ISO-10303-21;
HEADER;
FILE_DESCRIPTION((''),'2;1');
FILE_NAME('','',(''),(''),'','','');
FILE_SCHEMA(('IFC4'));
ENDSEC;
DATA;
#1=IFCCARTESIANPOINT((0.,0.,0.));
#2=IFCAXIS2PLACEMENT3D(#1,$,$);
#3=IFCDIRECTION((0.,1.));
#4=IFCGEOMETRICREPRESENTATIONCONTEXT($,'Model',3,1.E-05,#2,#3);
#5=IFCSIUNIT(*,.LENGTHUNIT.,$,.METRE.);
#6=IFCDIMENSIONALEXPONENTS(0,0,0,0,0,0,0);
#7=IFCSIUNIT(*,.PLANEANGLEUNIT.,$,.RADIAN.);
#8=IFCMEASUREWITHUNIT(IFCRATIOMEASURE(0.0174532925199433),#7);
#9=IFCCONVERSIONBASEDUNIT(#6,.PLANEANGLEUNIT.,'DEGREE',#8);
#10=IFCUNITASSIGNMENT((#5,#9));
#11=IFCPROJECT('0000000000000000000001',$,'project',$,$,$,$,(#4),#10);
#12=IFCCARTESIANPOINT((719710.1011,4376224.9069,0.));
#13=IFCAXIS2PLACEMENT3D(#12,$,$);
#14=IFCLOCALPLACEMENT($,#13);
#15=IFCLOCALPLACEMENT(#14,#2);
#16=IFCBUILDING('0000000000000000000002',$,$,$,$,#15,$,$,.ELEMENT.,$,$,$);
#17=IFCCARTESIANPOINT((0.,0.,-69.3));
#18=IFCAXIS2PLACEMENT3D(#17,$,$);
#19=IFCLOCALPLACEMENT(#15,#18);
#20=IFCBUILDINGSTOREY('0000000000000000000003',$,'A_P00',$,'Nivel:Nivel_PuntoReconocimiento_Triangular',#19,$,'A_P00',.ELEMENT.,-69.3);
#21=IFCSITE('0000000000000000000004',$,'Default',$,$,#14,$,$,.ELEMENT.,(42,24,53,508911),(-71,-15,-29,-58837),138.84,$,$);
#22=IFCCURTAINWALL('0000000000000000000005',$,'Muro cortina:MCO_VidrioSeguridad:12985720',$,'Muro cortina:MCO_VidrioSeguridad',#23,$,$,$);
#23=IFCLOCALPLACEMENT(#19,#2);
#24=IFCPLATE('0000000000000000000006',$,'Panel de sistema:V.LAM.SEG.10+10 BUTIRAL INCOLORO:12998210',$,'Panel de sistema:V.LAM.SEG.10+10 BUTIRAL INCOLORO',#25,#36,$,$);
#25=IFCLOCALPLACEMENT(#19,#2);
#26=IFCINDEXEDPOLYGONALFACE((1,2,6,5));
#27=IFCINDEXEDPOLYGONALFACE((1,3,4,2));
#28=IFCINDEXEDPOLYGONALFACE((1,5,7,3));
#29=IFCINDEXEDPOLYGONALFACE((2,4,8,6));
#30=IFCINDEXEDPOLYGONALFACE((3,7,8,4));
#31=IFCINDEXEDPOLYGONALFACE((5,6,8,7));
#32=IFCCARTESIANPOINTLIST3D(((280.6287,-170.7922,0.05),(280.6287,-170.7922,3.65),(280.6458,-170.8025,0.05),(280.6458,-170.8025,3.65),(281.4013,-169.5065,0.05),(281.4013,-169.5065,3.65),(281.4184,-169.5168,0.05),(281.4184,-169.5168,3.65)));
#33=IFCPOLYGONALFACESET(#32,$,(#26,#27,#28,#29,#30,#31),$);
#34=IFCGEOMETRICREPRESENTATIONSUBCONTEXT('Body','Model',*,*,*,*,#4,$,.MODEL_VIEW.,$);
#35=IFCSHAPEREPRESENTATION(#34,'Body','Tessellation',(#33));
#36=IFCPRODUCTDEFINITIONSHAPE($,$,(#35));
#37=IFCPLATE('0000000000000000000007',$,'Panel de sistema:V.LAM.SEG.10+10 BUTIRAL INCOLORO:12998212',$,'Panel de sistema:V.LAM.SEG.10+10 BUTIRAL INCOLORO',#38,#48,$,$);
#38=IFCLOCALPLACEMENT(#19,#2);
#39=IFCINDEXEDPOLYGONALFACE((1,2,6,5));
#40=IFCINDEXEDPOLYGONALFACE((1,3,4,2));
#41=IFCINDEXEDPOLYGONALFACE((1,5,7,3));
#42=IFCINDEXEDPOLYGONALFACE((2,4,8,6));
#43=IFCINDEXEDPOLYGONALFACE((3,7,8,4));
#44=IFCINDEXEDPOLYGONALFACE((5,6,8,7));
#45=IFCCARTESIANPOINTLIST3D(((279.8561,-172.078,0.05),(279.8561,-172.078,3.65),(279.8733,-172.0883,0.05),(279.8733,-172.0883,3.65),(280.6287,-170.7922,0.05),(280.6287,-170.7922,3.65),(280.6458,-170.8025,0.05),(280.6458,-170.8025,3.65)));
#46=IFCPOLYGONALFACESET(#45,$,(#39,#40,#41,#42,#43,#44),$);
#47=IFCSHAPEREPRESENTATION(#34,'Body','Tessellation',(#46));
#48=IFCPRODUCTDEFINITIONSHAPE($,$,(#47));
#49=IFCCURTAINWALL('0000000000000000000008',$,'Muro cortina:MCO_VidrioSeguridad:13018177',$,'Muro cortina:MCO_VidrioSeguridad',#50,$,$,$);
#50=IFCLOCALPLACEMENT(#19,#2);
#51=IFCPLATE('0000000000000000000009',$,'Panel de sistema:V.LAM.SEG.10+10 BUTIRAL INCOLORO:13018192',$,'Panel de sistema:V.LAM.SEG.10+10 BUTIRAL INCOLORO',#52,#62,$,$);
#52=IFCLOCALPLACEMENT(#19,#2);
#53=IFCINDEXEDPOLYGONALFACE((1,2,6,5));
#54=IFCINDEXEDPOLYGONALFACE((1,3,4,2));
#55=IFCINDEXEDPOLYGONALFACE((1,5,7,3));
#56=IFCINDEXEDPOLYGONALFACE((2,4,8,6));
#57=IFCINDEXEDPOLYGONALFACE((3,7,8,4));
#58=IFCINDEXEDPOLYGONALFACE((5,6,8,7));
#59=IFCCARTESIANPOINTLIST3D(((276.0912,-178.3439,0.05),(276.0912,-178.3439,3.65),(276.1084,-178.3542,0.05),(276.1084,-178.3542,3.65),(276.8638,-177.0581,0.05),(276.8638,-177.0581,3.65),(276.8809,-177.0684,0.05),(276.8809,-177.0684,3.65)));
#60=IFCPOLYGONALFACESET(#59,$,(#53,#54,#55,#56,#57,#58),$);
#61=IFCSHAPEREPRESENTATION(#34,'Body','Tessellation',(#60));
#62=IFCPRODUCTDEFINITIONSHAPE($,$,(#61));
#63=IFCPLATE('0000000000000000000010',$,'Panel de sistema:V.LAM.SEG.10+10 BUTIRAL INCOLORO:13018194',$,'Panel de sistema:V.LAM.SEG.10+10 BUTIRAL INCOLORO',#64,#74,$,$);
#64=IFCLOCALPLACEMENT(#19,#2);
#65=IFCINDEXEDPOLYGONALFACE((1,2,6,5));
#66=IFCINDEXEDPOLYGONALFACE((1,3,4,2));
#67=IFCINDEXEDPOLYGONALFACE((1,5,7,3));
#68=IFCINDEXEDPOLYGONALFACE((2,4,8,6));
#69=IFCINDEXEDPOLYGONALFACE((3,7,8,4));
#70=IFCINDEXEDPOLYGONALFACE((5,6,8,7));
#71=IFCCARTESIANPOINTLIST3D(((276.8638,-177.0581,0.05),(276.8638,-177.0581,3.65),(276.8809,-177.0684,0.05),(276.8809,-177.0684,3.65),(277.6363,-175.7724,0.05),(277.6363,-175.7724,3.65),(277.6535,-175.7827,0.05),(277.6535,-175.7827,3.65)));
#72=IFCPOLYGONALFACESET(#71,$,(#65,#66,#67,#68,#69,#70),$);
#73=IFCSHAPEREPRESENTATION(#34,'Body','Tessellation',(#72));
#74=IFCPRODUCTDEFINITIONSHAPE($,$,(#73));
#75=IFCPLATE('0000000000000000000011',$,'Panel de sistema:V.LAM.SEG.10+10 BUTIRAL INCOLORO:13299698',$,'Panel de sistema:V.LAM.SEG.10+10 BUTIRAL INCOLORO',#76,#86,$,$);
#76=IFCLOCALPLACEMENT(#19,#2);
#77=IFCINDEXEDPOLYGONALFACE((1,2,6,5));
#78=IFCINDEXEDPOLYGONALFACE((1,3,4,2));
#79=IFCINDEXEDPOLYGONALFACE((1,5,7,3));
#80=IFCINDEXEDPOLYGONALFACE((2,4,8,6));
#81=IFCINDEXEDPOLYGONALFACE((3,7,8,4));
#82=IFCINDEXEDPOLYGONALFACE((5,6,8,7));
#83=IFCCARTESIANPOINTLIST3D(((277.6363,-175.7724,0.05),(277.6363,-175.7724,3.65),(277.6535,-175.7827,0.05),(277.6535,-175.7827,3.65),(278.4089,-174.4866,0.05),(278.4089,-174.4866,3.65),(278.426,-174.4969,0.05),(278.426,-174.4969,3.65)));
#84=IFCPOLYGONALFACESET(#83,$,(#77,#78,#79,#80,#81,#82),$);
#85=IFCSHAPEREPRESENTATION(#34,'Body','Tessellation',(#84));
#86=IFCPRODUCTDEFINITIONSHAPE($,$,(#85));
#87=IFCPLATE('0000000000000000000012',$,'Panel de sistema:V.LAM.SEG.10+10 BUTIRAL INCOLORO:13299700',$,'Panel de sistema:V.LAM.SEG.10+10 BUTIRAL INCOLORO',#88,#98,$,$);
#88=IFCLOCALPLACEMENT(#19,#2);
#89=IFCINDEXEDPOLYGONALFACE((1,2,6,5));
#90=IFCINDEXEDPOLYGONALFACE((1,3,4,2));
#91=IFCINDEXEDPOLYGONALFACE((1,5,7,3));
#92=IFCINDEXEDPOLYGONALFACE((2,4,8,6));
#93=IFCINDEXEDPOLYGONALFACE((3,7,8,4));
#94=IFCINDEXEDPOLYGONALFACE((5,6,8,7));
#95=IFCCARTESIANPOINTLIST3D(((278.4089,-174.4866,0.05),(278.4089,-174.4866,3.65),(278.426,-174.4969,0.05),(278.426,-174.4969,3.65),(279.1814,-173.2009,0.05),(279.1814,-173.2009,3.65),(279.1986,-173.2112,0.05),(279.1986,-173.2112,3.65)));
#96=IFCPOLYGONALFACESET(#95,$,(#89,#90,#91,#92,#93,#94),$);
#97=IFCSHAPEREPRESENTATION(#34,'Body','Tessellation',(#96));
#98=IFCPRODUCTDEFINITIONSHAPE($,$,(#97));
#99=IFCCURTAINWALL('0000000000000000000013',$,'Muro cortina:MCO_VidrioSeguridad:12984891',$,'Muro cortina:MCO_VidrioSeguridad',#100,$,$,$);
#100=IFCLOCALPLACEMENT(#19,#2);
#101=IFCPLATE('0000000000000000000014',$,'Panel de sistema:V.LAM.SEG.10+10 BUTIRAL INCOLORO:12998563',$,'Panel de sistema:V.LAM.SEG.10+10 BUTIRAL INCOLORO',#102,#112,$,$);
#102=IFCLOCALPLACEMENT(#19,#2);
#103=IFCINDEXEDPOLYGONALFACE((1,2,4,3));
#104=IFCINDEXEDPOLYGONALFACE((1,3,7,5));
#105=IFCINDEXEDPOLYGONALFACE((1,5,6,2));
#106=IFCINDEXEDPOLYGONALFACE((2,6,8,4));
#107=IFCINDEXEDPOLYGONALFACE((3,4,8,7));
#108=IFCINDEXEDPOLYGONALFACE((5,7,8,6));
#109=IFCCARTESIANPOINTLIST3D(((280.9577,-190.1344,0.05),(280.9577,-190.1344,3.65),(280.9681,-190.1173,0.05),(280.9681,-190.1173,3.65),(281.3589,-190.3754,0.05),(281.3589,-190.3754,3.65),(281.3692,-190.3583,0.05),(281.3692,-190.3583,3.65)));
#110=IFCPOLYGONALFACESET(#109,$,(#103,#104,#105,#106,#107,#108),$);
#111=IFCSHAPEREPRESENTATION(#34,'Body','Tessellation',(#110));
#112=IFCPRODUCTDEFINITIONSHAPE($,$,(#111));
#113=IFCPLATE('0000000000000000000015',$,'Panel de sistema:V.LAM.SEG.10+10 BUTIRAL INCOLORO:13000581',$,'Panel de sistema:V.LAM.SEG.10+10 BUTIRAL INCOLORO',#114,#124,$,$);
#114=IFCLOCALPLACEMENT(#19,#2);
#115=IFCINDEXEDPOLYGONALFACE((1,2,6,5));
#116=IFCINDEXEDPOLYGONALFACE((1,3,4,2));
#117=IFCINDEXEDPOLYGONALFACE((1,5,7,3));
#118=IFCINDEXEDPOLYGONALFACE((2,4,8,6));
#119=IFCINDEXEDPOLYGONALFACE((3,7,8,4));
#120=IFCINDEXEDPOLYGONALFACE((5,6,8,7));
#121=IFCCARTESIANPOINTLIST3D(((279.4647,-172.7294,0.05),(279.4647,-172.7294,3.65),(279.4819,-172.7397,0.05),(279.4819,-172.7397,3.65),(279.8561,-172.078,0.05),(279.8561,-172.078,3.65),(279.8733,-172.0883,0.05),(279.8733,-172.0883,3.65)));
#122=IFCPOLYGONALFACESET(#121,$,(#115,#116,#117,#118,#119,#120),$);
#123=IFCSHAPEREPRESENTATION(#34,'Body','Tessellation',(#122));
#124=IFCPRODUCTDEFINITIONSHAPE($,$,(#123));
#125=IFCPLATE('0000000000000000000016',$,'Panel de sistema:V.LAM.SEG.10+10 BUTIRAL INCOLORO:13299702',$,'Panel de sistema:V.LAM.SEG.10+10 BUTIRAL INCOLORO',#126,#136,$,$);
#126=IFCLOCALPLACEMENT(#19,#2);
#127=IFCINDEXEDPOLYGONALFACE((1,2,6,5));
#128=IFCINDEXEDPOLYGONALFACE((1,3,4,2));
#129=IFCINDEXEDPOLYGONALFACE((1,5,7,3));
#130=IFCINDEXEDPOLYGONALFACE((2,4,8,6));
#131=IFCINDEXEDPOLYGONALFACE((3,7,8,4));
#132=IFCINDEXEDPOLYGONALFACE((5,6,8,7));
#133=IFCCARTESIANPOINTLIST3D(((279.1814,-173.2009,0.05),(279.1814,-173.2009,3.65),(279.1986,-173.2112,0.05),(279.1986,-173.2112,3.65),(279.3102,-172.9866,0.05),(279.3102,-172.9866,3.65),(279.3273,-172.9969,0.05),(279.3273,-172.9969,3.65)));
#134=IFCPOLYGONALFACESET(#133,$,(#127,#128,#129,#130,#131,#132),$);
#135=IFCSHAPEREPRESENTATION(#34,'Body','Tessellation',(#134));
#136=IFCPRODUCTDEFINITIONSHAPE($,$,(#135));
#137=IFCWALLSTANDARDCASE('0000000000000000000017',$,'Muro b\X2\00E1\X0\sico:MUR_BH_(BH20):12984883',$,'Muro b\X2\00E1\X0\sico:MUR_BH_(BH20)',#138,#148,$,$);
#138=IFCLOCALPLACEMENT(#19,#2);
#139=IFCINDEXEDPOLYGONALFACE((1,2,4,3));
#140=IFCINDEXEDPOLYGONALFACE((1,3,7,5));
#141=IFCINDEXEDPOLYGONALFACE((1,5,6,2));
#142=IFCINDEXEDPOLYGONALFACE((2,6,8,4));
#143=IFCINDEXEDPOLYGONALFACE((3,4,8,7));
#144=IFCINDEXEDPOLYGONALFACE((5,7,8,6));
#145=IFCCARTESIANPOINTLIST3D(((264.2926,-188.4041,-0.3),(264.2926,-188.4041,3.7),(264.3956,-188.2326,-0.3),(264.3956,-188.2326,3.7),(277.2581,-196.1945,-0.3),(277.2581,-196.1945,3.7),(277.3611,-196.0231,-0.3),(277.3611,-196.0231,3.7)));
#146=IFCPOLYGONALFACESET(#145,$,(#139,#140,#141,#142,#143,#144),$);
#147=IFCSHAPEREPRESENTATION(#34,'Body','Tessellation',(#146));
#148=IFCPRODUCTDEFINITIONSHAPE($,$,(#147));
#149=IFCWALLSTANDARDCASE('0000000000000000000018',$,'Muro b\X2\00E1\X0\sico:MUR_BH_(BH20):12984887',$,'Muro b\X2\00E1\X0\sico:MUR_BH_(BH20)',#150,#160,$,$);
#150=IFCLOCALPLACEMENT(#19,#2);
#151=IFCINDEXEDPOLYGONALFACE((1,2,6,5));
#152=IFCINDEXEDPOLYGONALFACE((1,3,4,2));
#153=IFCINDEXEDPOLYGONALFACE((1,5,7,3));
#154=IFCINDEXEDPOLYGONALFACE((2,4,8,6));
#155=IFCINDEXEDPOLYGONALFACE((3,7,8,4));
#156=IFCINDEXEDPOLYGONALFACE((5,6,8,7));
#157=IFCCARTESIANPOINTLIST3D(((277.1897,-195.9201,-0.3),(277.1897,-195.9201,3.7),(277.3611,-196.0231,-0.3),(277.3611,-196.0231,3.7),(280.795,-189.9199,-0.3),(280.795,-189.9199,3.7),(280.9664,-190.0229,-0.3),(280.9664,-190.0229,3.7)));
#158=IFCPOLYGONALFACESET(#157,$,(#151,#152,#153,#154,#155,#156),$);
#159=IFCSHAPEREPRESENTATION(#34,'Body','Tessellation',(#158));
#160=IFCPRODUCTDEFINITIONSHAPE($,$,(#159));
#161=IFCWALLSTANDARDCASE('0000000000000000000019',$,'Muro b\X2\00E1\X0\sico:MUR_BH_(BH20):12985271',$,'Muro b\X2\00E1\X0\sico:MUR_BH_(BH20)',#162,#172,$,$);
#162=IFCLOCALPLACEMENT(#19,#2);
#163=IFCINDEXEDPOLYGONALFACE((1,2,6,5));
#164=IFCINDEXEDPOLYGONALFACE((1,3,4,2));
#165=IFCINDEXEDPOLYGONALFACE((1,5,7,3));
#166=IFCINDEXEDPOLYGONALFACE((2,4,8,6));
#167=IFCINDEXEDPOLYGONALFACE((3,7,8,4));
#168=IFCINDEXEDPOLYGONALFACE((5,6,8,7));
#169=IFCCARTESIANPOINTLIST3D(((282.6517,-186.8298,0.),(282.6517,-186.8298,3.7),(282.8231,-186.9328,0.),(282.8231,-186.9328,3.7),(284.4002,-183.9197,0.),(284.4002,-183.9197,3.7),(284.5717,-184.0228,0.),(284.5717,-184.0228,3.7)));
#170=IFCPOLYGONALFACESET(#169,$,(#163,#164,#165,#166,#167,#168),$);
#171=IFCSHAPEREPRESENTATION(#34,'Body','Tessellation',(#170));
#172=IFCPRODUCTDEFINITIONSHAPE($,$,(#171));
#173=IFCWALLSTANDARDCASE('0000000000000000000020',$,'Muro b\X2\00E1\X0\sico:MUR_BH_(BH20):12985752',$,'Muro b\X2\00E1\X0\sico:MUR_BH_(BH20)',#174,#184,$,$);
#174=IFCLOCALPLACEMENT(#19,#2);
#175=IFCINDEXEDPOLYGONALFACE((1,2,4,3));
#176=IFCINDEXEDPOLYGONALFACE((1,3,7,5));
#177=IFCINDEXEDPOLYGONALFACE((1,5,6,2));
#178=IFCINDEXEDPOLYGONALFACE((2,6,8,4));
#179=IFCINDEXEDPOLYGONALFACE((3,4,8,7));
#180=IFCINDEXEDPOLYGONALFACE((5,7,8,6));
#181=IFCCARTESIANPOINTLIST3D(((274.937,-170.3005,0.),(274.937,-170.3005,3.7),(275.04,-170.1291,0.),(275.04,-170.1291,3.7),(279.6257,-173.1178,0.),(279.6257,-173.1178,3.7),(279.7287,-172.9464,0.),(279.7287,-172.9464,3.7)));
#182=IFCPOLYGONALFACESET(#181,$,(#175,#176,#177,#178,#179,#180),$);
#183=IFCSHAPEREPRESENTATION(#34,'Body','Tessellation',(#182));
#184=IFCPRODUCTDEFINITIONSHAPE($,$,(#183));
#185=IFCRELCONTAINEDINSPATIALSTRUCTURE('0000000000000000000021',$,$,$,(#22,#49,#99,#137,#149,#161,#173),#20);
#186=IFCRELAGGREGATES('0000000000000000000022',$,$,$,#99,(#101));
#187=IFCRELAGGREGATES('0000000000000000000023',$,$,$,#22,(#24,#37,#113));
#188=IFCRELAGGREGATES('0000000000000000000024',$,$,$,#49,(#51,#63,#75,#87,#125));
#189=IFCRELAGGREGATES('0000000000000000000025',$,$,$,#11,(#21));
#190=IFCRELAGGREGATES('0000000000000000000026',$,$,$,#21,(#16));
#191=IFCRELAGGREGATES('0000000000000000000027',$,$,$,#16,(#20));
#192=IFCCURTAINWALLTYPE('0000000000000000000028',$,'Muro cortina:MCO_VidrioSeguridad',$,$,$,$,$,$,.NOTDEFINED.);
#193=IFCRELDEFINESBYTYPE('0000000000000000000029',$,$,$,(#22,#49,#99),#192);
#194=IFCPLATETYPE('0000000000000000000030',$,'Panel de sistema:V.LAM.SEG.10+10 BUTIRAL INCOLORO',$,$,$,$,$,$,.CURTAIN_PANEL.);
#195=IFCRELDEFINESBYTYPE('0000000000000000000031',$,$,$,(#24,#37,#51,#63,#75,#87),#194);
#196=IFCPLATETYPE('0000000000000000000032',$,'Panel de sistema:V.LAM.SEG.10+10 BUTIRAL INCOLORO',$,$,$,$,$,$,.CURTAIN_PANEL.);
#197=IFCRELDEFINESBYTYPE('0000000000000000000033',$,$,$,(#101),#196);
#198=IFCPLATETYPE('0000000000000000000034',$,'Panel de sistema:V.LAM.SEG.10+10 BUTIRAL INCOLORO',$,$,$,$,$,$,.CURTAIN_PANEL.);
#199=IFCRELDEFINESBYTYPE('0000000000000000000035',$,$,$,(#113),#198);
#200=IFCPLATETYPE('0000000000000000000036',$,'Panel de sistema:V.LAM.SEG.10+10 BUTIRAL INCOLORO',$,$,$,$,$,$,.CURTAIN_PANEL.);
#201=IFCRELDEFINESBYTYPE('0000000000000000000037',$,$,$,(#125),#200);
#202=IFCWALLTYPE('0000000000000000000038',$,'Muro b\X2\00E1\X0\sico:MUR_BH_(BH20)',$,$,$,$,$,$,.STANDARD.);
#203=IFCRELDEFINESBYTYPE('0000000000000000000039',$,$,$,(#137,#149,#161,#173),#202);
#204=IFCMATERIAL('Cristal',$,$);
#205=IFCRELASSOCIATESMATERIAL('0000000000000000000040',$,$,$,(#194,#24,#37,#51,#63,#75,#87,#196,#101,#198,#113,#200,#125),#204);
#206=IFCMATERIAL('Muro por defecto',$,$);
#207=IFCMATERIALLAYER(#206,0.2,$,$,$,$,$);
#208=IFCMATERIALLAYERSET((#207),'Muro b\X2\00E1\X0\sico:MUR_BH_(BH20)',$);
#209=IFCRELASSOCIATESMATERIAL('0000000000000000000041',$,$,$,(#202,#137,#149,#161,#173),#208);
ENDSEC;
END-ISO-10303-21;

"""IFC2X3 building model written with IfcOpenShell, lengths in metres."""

from ifc_helpers import new_model, entity, si_unit, converted_unit, direction, frame, frame_2d, origin, origin_2d_with_axis, place, context, subcontext, project, spatial, rectangle, extrude, source, transform, mapped, material, layer, layer_set, layer_usage, type_object, type_shapes, element, aggregate, save


model = new_model("IFC2X3")

# Units and contexts
model_context = context("Model", 3, precision=1e-05, world=origin(), true_north=direction((0.0, 1.0)))
body_context = subcontext(model_context, "Body", "Model", "MODEL_VIEW")
ifc_project = project(units=[si_unit("LENGTHUNIT", "METRE"), converted_unit("PLANEANGLEUNIT", "DEGREE", entity("IfcRatioMeasure", 0.0174532925199433), si_unit("PLANEANGLEUNIT", "RADIAN"), dimensions=[0, 0, 0, 0, 0, 0, 0])], contexts=[model_context])

# Site, building, storey
site_placement = place(None, frame((719710.1011, 4376224.9069, 0.0)))
site = spatial("IfcSite", under=ifc_project, at=site_placement, Name="Default", CompositionType="ELEMENT", RefLatitude=(42, 24, 53, 508911), RefLongitude=(-71, -15, -29, -58837), RefElevation=138.84)
building_placement = place(site_placement, origin())
building = spatial("IfcBuilding", under=site, at=building_placement, CompositionType="ELEMENT")
storey_placement = place(building_placement, frame((0.0, 0.0, -69.3)))
storey = spatial("IfcBuildingStorey", under=building, at=storey_placement, Name="A_P00", ObjectType="Nivel:Nivel_PuntoReconocimiento_Triangular", LongName="A_P00", CompositionType="ELEMENT", Elevation=-69.3)

# Curtain walls, plates
curtain_wall_type = type_object("IfcCurtainWallType", Name="Muro cortina:MCO_VidrioSeguridad", PredefinedType="NOTDEFINED")
curtain_wall_1_placement = place(storey_placement, frame((0.0, 0.0, 69.3)))
curtain_wall_1 = element("IfcCurtainWall", 1, at=curtain_wall_1_placement, inside=storey, type_object=curtain_wall_type, Name="Muro cortina:MCO_VidrioSeguridad:12985720", ObjectType="Muro cortina:MCO_VidrioSeguridad")
ifc_material_1 = material(Name="Cristal")
plate_type_1 = type_object("IfcPlateType", Name="Panel de sistema:V.LAM.SEG.10+10 BUTIRAL INCOLORO", PredefinedType="CURTAIN_PANEL", material=ifc_material_1)
shared_shape_1 = source(origin(), body_context, "Body", "SweptSolid", [
    extrude(rectangle(XDim=0.02, YDim=1.5, at=origin_2d_with_axis()), frame((0.0, 0.0, 0.0), z_axis=(0.0, 0.0, 1.0), x_axis=(0.0, 1.0, 0.0)), (0.0, 0.0, 1.0), 3.6),
])
type_shapes(plate_type_1, [shared_shape_1])
plate_1_placement = place(curtain_wall_1_placement, frame((281.0236, -170.1545, -69.25), z_axis=(0.0, 0.0, 1.0), x_axis=(-0.515038, -0.857167, 0.0)))
plate_1 = element("IfcPlate", 2, at=plate_1_placement, type_object=plate_type_1, material=ifc_material_1, Name="Panel de sistema:V.LAM.SEG.10+10 BUTIRAL INCOLORO:12998210", ObjectType="Panel de sistema:V.LAM.SEG.10+10 BUTIRAL INCOLORO", context=body_context, shape_type="MappedRepresentation", body=[
    mapped(shared_shape_1, transform((0.0, 0.0, 0.0), scale=1.0)),
])
plate_2_placement = place(curtain_wall_1_placement, frame((280.251, -171.4403, -69.25), z_axis=(0.0, 0.0, 1.0), x_axis=(-0.515038, -0.857167, 0.0)))
plate_2 = element("IfcPlate", 3, at=plate_2_placement, type_object=plate_type_1, material=ifc_material_1, Name="Panel de sistema:V.LAM.SEG.10+10 BUTIRAL INCOLORO:12998212", ObjectType="Panel de sistema:V.LAM.SEG.10+10 BUTIRAL INCOLORO", context=body_context, shape_type="MappedRepresentation", body=[
    mapped(shared_shape_1, transform((0.0, 0.0, 0.0), scale=1.0)),
])
curtain_wall_2_placement = place(storey_placement, frame((0.0, 0.0, 69.3)))
curtain_wall_2 = element("IfcCurtainWall", 4, at=curtain_wall_2_placement, inside=storey, type_object=curtain_wall_type, Name="Muro cortina:MCO_VidrioSeguridad:13018177", ObjectType="Muro cortina:MCO_VidrioSeguridad")
plate_3_placement = place(curtain_wall_2_placement, frame((276.4861, -177.7062, -69.25), z_axis=(0.0, 0.0, 1.0), x_axis=(0.515038, 0.857167, 0.0)))
plate_3 = element("IfcPlate", 5, at=plate_3_placement, type_object=plate_type_1, material=ifc_material_1, Name="Panel de sistema:V.LAM.SEG.10+10 BUTIRAL INCOLORO:13018192", ObjectType="Panel de sistema:V.LAM.SEG.10+10 BUTIRAL INCOLORO", context=body_context, shape_type="MappedRepresentation", body=[
    mapped(shared_shape_1, transform((0.0, 0.0, 0.0), scale=1.0)),
])
plate_4_placement = place(curtain_wall_2_placement, frame((277.2586, -176.4204, -69.25), z_axis=(0.0, 0.0, 1.0), x_axis=(0.515038, 0.857167, 0.0)))
plate_4 = element("IfcPlate", 6, at=plate_4_placement, type_object=plate_type_1, material=ifc_material_1, Name="Panel de sistema:V.LAM.SEG.10+10 BUTIRAL INCOLORO:13018194", ObjectType="Panel de sistema:V.LAM.SEG.10+10 BUTIRAL INCOLORO", context=body_context, shape_type="MappedRepresentation", body=[
    mapped(shared_shape_1, transform((0.0, 0.0, 0.0), scale=1.0)),
])
plate_5_placement = place(curtain_wall_2_placement, frame((278.0312, -175.1346, -69.25), z_axis=(0.0, 0.0, 1.0), x_axis=(0.515038, 0.857167, 0.0)))
plate_5 = element("IfcPlate", 7, at=plate_5_placement, type_object=plate_type_1, material=ifc_material_1, Name="Panel de sistema:V.LAM.SEG.10+10 BUTIRAL INCOLORO:13299698", ObjectType="Panel de sistema:V.LAM.SEG.10+10 BUTIRAL INCOLORO", context=body_context, shape_type="MappedRepresentation", body=[
    mapped(shared_shape_1, transform((0.0, 0.0, 0.0), scale=1.0)),
])
plate_6_placement = place(curtain_wall_2_placement, frame((278.8037, -173.8489, -69.25), z_axis=(0.0, 0.0, 1.0), x_axis=(0.515038, 0.857167, 0.0)))
plate_6 = element("IfcPlate", 8, at=plate_6_placement, type_object=plate_type_1, material=ifc_material_1, Name="Panel de sistema:V.LAM.SEG.10+10 BUTIRAL INCOLORO:13299700", ObjectType="Panel de sistema:V.LAM.SEG.10+10 BUTIRAL INCOLORO", context=body_context, shape_type="MappedRepresentation", body=[
    mapped(shared_shape_1, transform((0.0, 0.0, 0.0), scale=1.0)),
])

# Curtain wall, plate
curtain_wall_3_placement = place(storey_placement, frame((0.0, 0.0, 69.3)))
curtain_wall_3 = element("IfcCurtainWall", 9, at=curtain_wall_3_placement, inside=storey, type_object=curtain_wall_type, Name="Muro cortina:MCO_VidrioSeguridad:12984891", ObjectType="Muro cortina:MCO_VidrioSeguridad")
plate_type_2 = type_object("IfcPlateType", Name="Panel de sistema:V.LAM.SEG.10+10 BUTIRAL INCOLORO", PredefinedType="CURTAIN_PANEL", material=ifc_material_1)
shared_shape_2 = source(origin(), body_context, "Body", "SweptSolid", [
    extrude(rectangle(XDim=0.02, YDim=0.468, at=origin_2d_with_axis()), frame((0.0, 0.0, 0.0), z_axis=(0.0, 0.0, 1.0), x_axis=(0.0, 1.0, 0.0)), (0.0, 0.0, 1.0), 3.6),
])
type_shapes(plate_type_2, [shared_shape_2])
plate_7_placement = place(curtain_wall_3_placement, frame((281.1635, -190.2463, -69.25), z_axis=(0.0, 0.0, 1.0), x_axis=(-0.857167, 0.515038, 0.0)))
plate_7 = element("IfcPlate", 10, at=plate_7_placement, type_object=plate_type_2, material=ifc_material_1, Name="Panel de sistema:V.LAM.SEG.10+10 BUTIRAL INCOLORO:12998563", ObjectType="Panel de sistema:V.LAM.SEG.10+10 BUTIRAL INCOLORO", context=body_context, shape_type="MappedRepresentation", body=[
    mapped(shared_shape_2, transform((0.0, 0.0, 0.0), scale=1.0)),
])
aggregate(curtain_wall_3, [plate_7])

# Plates
plate_type_3 = type_object("IfcPlateType", Name="Panel de sistema:V.LAM.SEG.10+10 BUTIRAL INCOLORO", PredefinedType="CURTAIN_PANEL", material=ifc_material_1)
shared_shape_3 = source(origin(), body_context, "Body", "SweptSolid", [
    extrude(rectangle(XDim=0.02, YDim=0.76, at=origin_2d_with_axis()), frame((0.0, 0.0, 0.0), z_axis=(0.0, 0.0, 1.0), x_axis=(0.0, 1.0, 0.0)), (0.0, 0.0, 1.0), 3.6),
])
type_shapes(plate_type_3, [shared_shape_3])
plate_8_placement = place(curtain_wall_1_placement, frame((279.669, -172.4089, -69.25), z_axis=(0.0, 0.0, 1.0), x_axis=(-0.515038, -0.857167, 0.0)))
plate_8 = element("IfcPlate", 11, at=plate_8_placement, type_object=plate_type_3, material=ifc_material_1, Name="Panel de sistema:V.LAM.SEG.10+10 BUTIRAL INCOLORO:13000581", ObjectType="Panel de sistema:V.LAM.SEG.10+10 BUTIRAL INCOLORO", context=body_context, shape_type="MappedRepresentation", body=[
    mapped(shared_shape_3, transform((0.0, 0.0, 0.0), scale=1.0)),
])
aggregate(curtain_wall_1, [plate_1, plate_2, plate_8])
plate_type_4 = type_object("IfcPlateType", Name="Panel de sistema:V.LAM.SEG.10+10 BUTIRAL INCOLORO", PredefinedType="CURTAIN_PANEL", material=ifc_material_1)
shared_shape_4 = source(origin(), body_context, "Body", "SweptSolid", [
    extrude(rectangle(XDim=0.02, YDim=0.25, at=origin_2d_with_axis()), frame((0.0, 0.0, 0.0), z_axis=(0.0, 0.0, 1.0), x_axis=(0.0, 1.0, 0.0)), (0.0, 0.0, 1.0), 3.6),
])
type_shapes(plate_type_4, [shared_shape_4])
plate_9_placement = place(curtain_wall_2_placement, frame((279.2544, -173.0989, -69.25), z_axis=(0.0, 0.0, 1.0), x_axis=(0.515038, 0.857167, 0.0)))
plate_9 = element("IfcPlate", 12, at=plate_9_placement, type_object=plate_type_4, material=ifc_material_1, Name="Panel de sistema:V.LAM.SEG.10+10 BUTIRAL INCOLORO:13299702", ObjectType="Panel de sistema:V.LAM.SEG.10+10 BUTIRAL INCOLORO", context=body_context, shape_type="MappedRepresentation", body=[
    mapped(shared_shape_4, transform((0.0, 0.0, 0.0), scale=1.0)),
])
aggregate(curtain_wall_2, [plate_3, plate_4, plate_5, plate_6, plate_9])

# Walls
ifc_material_2 = material(Name="Muro por defecto")
ifc_layer_1 = layer(ifc_material_2, 0.2)
ifc_layer_set_1 = layer_set([ifc_layer_1], Name="Muro básico:MUR_BH_(BH20)")
ifc_layer_usage_1 = layer_usage(ifc_layer_set_1, "AXIS2", "NEGATIVE", 0.1)
wall_type_1 = type_object("IfcWallType", Name="Muro básico:MUR_BH_(BH20)", PredefinedType="STANDARD", material=ifc_layer_set_1)
wall_1_placement = place(storey_placement, frame((277.3096, -196.1088, -0.3), z_axis=(0.0, 0.0, 1.0), x_axis=(-0.857167, 0.515038, 0.0)))
element("IfcWallStandardCase", 13, at=wall_1_placement, inside=storey, type_object=wall_type_1, material=ifc_layer_usage_1, Name="Muro básico:MUR_BH_(BH20):12984883", ObjectType="Muro básico:MUR_BH_(BH20)", context=body_context, shape_type="SweptSolid", body=[
    extrude(rectangle(XDim=15.126, YDim=0.2, at=frame_2d((7.563, 0.0), x_axis=(-1.0, 0.0))), origin(), (0.0, 0.0, 1.0), 4.0),
])
ifc_layer_usage_2 = layer_usage(ifc_layer_set_1, "AXIS2", "NEGATIVE", 0.1)
wall_2_placement = place(storey_placement, frame((280.8807, -189.9714, -0.3), z_axis=(0.0, 0.0, 1.0), x_axis=(-0.515038, -0.857167, 0.0)))
element("IfcWallStandardCase", 14, at=wall_2_placement, inside=storey, type_object=wall_type_1, material=ifc_layer_usage_2, Name="Muro básico:MUR_BH_(BH20):12984887", ObjectType="Muro básico:MUR_BH_(BH20)", context=body_context, shape_type="SweptSolid", body=[
    extrude(rectangle(XDim=7.0, YDim=0.2, at=frame_2d((3.5, 0.0), x_axis=(-1.0, 0.0))), origin(), (0.0, 0.0, 1.0), 4.0),
])
ifc_layer_usage_3 = layer_usage(ifc_layer_set_1, "AXIS2", "NEGATIVE", 0.1)
wall_3_placement = place(storey_placement, frame((282.7374, -186.8813, 0.0), z_axis=(0.0, 0.0, 1.0), x_axis=(0.515038, 0.857167, 0.0)))
element("IfcWallStandardCase", 15, at=wall_3_placement, inside=storey, type_object=wall_type_1, material=ifc_layer_usage_3, Name="Muro básico:MUR_BH_(BH20):12985271", ObjectType="Muro básico:MUR_BH_(BH20)", context=body_context, shape_type="SweptSolid", body=[
    extrude(rectangle(XDim=3.395, YDim=0.2, at=frame_2d((1.6975, 0.0), x_axis=(-1.0, 0.0))), origin(), (0.0, 0.0, 1.0), 3.7),
])
ifc_layer_usage_4 = layer_usage(ifc_layer_set_1, "AXIS2", "NEGATIVE", 0.1)
wall_4_placement = place(storey_placement, frame((279.6772, -173.0321, 0.0), z_axis=(0.0, 0.0, 1.0), x_axis=(-0.857167, 0.515038, 0.0)))
element("IfcWallStandardCase", 16, at=wall_4_placement, inside=storey, type_object=wall_type_1, material=ifc_layer_usage_4, Name="Muro básico:MUR_BH_(BH20):12985752", ObjectType="Muro básico:MUR_BH_(BH20)", context=body_context, shape_type="SweptSolid", body=[
    extrude(rectangle(XDim=5.47, YDim=0.2, at=frame_2d((2.735, 0.0), x_axis=(-1.0, 0.0))), origin(), (0.0, 0.0, 1.0), 3.7),
])

save(model, "model.ifc")
